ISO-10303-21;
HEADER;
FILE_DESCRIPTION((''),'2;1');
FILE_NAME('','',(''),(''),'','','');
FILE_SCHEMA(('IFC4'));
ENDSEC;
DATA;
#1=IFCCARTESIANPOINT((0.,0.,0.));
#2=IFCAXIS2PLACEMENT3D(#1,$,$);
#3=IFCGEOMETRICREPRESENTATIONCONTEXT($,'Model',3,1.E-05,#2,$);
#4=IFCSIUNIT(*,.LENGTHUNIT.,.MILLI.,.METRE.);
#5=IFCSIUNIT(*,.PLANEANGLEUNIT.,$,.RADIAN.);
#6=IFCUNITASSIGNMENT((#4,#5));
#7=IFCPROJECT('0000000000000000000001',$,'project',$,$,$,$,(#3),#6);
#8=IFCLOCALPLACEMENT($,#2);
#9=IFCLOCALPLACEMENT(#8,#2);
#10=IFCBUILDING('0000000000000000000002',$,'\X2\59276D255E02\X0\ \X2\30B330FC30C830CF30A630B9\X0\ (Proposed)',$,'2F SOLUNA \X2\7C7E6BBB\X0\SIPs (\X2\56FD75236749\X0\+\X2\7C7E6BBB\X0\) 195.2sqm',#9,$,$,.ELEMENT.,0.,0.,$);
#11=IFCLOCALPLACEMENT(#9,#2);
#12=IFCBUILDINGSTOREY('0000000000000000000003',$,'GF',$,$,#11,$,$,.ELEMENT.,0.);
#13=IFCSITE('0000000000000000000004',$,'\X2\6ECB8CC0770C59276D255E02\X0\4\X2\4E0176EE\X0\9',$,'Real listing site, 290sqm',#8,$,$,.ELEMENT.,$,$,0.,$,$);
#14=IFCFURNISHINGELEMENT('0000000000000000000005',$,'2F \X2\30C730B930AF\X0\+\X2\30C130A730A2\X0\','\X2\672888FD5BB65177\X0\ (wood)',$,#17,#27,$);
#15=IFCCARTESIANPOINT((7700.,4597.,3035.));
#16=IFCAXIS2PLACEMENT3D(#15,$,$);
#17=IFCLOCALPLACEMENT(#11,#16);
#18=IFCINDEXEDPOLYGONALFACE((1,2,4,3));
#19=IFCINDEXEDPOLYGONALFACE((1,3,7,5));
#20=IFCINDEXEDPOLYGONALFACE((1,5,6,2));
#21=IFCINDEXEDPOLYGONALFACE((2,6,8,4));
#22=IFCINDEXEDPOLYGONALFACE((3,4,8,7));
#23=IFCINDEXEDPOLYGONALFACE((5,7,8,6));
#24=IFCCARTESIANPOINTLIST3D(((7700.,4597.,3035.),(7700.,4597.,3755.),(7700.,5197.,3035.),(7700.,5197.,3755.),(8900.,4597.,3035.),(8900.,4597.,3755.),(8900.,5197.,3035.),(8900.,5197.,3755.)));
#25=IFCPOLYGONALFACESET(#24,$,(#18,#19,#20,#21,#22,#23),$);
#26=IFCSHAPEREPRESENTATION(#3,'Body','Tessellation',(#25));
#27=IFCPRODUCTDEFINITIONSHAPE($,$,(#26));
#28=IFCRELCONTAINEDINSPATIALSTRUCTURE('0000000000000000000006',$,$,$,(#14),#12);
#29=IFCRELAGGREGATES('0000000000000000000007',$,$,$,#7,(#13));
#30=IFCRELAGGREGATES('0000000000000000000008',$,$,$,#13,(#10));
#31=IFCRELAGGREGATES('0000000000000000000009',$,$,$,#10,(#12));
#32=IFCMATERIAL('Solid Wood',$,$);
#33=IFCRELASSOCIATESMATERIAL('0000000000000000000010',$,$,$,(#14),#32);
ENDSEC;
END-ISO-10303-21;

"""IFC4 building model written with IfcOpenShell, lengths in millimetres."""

from ifc_helpers import new_model, si_unit, frame, frame_2d, origin, place, context, project, spatial, rectangle, extrude, material, element, save


model = new_model("IFC4")

# Units and contexts
model_context = context("Model", 3, precision=1e-05, world=origin())
ifc_project = project(units=[si_unit("LENGTHUNIT", "METRE", prefix="MILLI"), si_unit("PLANEANGLEUNIT", "RADIAN")], contexts=[model_context])

# Site, building, storey
site_placement = place(None, origin())
site = spatial("IfcSite", under=ifc_project, at=site_placement, Name="滋賀県大津市4丁目9", ObjectType="Real listing site, 290sqm", CompositionType="ELEMENT", RefElevation=0.0)
building_placement = place(site_placement, origin())
building = spatial("IfcBuilding", under=site, at=building_placement, Name="大津市 コートハウス (Proposed)", ObjectType="2F SOLUNA 籾殻SIPs (国産杉+籾殻) 195.2sqm", CompositionType="ELEMENT", ElevationOfRefHeight=0.0, ElevationOfTerrain=0.0)
storey_placement = place(building_placement, origin())
storey = spatial("IfcBuildingStorey", under=building, at=storey_placement, Name="GF", CompositionType="ELEMENT", Elevation=0.0)

# Shared definitions
ifc_material_1 = material(Name="Solid Wood")

# Furnishing element
furnishing_1_placement = place(storey_placement, frame((7700.0, 4597.0, 3035.0)))
element("IfcFurnishingElement", 1, at=furnishing_1_placement, inside=storey, material=ifc_material_1, Name="2F デスク+チェア", Description="木製家具 (wood)", context=model_context, shape_type="SweptSolid", body=[
    extrude(rectangle(XDim=1200.0, YDim=600.0, at=frame_2d((600.0, 300.0))), frame((7700.0, 4597.0, 3035.0)), (0.0, 0.0, 1.0), 720.0),
])

save(model, "model.ifc")
